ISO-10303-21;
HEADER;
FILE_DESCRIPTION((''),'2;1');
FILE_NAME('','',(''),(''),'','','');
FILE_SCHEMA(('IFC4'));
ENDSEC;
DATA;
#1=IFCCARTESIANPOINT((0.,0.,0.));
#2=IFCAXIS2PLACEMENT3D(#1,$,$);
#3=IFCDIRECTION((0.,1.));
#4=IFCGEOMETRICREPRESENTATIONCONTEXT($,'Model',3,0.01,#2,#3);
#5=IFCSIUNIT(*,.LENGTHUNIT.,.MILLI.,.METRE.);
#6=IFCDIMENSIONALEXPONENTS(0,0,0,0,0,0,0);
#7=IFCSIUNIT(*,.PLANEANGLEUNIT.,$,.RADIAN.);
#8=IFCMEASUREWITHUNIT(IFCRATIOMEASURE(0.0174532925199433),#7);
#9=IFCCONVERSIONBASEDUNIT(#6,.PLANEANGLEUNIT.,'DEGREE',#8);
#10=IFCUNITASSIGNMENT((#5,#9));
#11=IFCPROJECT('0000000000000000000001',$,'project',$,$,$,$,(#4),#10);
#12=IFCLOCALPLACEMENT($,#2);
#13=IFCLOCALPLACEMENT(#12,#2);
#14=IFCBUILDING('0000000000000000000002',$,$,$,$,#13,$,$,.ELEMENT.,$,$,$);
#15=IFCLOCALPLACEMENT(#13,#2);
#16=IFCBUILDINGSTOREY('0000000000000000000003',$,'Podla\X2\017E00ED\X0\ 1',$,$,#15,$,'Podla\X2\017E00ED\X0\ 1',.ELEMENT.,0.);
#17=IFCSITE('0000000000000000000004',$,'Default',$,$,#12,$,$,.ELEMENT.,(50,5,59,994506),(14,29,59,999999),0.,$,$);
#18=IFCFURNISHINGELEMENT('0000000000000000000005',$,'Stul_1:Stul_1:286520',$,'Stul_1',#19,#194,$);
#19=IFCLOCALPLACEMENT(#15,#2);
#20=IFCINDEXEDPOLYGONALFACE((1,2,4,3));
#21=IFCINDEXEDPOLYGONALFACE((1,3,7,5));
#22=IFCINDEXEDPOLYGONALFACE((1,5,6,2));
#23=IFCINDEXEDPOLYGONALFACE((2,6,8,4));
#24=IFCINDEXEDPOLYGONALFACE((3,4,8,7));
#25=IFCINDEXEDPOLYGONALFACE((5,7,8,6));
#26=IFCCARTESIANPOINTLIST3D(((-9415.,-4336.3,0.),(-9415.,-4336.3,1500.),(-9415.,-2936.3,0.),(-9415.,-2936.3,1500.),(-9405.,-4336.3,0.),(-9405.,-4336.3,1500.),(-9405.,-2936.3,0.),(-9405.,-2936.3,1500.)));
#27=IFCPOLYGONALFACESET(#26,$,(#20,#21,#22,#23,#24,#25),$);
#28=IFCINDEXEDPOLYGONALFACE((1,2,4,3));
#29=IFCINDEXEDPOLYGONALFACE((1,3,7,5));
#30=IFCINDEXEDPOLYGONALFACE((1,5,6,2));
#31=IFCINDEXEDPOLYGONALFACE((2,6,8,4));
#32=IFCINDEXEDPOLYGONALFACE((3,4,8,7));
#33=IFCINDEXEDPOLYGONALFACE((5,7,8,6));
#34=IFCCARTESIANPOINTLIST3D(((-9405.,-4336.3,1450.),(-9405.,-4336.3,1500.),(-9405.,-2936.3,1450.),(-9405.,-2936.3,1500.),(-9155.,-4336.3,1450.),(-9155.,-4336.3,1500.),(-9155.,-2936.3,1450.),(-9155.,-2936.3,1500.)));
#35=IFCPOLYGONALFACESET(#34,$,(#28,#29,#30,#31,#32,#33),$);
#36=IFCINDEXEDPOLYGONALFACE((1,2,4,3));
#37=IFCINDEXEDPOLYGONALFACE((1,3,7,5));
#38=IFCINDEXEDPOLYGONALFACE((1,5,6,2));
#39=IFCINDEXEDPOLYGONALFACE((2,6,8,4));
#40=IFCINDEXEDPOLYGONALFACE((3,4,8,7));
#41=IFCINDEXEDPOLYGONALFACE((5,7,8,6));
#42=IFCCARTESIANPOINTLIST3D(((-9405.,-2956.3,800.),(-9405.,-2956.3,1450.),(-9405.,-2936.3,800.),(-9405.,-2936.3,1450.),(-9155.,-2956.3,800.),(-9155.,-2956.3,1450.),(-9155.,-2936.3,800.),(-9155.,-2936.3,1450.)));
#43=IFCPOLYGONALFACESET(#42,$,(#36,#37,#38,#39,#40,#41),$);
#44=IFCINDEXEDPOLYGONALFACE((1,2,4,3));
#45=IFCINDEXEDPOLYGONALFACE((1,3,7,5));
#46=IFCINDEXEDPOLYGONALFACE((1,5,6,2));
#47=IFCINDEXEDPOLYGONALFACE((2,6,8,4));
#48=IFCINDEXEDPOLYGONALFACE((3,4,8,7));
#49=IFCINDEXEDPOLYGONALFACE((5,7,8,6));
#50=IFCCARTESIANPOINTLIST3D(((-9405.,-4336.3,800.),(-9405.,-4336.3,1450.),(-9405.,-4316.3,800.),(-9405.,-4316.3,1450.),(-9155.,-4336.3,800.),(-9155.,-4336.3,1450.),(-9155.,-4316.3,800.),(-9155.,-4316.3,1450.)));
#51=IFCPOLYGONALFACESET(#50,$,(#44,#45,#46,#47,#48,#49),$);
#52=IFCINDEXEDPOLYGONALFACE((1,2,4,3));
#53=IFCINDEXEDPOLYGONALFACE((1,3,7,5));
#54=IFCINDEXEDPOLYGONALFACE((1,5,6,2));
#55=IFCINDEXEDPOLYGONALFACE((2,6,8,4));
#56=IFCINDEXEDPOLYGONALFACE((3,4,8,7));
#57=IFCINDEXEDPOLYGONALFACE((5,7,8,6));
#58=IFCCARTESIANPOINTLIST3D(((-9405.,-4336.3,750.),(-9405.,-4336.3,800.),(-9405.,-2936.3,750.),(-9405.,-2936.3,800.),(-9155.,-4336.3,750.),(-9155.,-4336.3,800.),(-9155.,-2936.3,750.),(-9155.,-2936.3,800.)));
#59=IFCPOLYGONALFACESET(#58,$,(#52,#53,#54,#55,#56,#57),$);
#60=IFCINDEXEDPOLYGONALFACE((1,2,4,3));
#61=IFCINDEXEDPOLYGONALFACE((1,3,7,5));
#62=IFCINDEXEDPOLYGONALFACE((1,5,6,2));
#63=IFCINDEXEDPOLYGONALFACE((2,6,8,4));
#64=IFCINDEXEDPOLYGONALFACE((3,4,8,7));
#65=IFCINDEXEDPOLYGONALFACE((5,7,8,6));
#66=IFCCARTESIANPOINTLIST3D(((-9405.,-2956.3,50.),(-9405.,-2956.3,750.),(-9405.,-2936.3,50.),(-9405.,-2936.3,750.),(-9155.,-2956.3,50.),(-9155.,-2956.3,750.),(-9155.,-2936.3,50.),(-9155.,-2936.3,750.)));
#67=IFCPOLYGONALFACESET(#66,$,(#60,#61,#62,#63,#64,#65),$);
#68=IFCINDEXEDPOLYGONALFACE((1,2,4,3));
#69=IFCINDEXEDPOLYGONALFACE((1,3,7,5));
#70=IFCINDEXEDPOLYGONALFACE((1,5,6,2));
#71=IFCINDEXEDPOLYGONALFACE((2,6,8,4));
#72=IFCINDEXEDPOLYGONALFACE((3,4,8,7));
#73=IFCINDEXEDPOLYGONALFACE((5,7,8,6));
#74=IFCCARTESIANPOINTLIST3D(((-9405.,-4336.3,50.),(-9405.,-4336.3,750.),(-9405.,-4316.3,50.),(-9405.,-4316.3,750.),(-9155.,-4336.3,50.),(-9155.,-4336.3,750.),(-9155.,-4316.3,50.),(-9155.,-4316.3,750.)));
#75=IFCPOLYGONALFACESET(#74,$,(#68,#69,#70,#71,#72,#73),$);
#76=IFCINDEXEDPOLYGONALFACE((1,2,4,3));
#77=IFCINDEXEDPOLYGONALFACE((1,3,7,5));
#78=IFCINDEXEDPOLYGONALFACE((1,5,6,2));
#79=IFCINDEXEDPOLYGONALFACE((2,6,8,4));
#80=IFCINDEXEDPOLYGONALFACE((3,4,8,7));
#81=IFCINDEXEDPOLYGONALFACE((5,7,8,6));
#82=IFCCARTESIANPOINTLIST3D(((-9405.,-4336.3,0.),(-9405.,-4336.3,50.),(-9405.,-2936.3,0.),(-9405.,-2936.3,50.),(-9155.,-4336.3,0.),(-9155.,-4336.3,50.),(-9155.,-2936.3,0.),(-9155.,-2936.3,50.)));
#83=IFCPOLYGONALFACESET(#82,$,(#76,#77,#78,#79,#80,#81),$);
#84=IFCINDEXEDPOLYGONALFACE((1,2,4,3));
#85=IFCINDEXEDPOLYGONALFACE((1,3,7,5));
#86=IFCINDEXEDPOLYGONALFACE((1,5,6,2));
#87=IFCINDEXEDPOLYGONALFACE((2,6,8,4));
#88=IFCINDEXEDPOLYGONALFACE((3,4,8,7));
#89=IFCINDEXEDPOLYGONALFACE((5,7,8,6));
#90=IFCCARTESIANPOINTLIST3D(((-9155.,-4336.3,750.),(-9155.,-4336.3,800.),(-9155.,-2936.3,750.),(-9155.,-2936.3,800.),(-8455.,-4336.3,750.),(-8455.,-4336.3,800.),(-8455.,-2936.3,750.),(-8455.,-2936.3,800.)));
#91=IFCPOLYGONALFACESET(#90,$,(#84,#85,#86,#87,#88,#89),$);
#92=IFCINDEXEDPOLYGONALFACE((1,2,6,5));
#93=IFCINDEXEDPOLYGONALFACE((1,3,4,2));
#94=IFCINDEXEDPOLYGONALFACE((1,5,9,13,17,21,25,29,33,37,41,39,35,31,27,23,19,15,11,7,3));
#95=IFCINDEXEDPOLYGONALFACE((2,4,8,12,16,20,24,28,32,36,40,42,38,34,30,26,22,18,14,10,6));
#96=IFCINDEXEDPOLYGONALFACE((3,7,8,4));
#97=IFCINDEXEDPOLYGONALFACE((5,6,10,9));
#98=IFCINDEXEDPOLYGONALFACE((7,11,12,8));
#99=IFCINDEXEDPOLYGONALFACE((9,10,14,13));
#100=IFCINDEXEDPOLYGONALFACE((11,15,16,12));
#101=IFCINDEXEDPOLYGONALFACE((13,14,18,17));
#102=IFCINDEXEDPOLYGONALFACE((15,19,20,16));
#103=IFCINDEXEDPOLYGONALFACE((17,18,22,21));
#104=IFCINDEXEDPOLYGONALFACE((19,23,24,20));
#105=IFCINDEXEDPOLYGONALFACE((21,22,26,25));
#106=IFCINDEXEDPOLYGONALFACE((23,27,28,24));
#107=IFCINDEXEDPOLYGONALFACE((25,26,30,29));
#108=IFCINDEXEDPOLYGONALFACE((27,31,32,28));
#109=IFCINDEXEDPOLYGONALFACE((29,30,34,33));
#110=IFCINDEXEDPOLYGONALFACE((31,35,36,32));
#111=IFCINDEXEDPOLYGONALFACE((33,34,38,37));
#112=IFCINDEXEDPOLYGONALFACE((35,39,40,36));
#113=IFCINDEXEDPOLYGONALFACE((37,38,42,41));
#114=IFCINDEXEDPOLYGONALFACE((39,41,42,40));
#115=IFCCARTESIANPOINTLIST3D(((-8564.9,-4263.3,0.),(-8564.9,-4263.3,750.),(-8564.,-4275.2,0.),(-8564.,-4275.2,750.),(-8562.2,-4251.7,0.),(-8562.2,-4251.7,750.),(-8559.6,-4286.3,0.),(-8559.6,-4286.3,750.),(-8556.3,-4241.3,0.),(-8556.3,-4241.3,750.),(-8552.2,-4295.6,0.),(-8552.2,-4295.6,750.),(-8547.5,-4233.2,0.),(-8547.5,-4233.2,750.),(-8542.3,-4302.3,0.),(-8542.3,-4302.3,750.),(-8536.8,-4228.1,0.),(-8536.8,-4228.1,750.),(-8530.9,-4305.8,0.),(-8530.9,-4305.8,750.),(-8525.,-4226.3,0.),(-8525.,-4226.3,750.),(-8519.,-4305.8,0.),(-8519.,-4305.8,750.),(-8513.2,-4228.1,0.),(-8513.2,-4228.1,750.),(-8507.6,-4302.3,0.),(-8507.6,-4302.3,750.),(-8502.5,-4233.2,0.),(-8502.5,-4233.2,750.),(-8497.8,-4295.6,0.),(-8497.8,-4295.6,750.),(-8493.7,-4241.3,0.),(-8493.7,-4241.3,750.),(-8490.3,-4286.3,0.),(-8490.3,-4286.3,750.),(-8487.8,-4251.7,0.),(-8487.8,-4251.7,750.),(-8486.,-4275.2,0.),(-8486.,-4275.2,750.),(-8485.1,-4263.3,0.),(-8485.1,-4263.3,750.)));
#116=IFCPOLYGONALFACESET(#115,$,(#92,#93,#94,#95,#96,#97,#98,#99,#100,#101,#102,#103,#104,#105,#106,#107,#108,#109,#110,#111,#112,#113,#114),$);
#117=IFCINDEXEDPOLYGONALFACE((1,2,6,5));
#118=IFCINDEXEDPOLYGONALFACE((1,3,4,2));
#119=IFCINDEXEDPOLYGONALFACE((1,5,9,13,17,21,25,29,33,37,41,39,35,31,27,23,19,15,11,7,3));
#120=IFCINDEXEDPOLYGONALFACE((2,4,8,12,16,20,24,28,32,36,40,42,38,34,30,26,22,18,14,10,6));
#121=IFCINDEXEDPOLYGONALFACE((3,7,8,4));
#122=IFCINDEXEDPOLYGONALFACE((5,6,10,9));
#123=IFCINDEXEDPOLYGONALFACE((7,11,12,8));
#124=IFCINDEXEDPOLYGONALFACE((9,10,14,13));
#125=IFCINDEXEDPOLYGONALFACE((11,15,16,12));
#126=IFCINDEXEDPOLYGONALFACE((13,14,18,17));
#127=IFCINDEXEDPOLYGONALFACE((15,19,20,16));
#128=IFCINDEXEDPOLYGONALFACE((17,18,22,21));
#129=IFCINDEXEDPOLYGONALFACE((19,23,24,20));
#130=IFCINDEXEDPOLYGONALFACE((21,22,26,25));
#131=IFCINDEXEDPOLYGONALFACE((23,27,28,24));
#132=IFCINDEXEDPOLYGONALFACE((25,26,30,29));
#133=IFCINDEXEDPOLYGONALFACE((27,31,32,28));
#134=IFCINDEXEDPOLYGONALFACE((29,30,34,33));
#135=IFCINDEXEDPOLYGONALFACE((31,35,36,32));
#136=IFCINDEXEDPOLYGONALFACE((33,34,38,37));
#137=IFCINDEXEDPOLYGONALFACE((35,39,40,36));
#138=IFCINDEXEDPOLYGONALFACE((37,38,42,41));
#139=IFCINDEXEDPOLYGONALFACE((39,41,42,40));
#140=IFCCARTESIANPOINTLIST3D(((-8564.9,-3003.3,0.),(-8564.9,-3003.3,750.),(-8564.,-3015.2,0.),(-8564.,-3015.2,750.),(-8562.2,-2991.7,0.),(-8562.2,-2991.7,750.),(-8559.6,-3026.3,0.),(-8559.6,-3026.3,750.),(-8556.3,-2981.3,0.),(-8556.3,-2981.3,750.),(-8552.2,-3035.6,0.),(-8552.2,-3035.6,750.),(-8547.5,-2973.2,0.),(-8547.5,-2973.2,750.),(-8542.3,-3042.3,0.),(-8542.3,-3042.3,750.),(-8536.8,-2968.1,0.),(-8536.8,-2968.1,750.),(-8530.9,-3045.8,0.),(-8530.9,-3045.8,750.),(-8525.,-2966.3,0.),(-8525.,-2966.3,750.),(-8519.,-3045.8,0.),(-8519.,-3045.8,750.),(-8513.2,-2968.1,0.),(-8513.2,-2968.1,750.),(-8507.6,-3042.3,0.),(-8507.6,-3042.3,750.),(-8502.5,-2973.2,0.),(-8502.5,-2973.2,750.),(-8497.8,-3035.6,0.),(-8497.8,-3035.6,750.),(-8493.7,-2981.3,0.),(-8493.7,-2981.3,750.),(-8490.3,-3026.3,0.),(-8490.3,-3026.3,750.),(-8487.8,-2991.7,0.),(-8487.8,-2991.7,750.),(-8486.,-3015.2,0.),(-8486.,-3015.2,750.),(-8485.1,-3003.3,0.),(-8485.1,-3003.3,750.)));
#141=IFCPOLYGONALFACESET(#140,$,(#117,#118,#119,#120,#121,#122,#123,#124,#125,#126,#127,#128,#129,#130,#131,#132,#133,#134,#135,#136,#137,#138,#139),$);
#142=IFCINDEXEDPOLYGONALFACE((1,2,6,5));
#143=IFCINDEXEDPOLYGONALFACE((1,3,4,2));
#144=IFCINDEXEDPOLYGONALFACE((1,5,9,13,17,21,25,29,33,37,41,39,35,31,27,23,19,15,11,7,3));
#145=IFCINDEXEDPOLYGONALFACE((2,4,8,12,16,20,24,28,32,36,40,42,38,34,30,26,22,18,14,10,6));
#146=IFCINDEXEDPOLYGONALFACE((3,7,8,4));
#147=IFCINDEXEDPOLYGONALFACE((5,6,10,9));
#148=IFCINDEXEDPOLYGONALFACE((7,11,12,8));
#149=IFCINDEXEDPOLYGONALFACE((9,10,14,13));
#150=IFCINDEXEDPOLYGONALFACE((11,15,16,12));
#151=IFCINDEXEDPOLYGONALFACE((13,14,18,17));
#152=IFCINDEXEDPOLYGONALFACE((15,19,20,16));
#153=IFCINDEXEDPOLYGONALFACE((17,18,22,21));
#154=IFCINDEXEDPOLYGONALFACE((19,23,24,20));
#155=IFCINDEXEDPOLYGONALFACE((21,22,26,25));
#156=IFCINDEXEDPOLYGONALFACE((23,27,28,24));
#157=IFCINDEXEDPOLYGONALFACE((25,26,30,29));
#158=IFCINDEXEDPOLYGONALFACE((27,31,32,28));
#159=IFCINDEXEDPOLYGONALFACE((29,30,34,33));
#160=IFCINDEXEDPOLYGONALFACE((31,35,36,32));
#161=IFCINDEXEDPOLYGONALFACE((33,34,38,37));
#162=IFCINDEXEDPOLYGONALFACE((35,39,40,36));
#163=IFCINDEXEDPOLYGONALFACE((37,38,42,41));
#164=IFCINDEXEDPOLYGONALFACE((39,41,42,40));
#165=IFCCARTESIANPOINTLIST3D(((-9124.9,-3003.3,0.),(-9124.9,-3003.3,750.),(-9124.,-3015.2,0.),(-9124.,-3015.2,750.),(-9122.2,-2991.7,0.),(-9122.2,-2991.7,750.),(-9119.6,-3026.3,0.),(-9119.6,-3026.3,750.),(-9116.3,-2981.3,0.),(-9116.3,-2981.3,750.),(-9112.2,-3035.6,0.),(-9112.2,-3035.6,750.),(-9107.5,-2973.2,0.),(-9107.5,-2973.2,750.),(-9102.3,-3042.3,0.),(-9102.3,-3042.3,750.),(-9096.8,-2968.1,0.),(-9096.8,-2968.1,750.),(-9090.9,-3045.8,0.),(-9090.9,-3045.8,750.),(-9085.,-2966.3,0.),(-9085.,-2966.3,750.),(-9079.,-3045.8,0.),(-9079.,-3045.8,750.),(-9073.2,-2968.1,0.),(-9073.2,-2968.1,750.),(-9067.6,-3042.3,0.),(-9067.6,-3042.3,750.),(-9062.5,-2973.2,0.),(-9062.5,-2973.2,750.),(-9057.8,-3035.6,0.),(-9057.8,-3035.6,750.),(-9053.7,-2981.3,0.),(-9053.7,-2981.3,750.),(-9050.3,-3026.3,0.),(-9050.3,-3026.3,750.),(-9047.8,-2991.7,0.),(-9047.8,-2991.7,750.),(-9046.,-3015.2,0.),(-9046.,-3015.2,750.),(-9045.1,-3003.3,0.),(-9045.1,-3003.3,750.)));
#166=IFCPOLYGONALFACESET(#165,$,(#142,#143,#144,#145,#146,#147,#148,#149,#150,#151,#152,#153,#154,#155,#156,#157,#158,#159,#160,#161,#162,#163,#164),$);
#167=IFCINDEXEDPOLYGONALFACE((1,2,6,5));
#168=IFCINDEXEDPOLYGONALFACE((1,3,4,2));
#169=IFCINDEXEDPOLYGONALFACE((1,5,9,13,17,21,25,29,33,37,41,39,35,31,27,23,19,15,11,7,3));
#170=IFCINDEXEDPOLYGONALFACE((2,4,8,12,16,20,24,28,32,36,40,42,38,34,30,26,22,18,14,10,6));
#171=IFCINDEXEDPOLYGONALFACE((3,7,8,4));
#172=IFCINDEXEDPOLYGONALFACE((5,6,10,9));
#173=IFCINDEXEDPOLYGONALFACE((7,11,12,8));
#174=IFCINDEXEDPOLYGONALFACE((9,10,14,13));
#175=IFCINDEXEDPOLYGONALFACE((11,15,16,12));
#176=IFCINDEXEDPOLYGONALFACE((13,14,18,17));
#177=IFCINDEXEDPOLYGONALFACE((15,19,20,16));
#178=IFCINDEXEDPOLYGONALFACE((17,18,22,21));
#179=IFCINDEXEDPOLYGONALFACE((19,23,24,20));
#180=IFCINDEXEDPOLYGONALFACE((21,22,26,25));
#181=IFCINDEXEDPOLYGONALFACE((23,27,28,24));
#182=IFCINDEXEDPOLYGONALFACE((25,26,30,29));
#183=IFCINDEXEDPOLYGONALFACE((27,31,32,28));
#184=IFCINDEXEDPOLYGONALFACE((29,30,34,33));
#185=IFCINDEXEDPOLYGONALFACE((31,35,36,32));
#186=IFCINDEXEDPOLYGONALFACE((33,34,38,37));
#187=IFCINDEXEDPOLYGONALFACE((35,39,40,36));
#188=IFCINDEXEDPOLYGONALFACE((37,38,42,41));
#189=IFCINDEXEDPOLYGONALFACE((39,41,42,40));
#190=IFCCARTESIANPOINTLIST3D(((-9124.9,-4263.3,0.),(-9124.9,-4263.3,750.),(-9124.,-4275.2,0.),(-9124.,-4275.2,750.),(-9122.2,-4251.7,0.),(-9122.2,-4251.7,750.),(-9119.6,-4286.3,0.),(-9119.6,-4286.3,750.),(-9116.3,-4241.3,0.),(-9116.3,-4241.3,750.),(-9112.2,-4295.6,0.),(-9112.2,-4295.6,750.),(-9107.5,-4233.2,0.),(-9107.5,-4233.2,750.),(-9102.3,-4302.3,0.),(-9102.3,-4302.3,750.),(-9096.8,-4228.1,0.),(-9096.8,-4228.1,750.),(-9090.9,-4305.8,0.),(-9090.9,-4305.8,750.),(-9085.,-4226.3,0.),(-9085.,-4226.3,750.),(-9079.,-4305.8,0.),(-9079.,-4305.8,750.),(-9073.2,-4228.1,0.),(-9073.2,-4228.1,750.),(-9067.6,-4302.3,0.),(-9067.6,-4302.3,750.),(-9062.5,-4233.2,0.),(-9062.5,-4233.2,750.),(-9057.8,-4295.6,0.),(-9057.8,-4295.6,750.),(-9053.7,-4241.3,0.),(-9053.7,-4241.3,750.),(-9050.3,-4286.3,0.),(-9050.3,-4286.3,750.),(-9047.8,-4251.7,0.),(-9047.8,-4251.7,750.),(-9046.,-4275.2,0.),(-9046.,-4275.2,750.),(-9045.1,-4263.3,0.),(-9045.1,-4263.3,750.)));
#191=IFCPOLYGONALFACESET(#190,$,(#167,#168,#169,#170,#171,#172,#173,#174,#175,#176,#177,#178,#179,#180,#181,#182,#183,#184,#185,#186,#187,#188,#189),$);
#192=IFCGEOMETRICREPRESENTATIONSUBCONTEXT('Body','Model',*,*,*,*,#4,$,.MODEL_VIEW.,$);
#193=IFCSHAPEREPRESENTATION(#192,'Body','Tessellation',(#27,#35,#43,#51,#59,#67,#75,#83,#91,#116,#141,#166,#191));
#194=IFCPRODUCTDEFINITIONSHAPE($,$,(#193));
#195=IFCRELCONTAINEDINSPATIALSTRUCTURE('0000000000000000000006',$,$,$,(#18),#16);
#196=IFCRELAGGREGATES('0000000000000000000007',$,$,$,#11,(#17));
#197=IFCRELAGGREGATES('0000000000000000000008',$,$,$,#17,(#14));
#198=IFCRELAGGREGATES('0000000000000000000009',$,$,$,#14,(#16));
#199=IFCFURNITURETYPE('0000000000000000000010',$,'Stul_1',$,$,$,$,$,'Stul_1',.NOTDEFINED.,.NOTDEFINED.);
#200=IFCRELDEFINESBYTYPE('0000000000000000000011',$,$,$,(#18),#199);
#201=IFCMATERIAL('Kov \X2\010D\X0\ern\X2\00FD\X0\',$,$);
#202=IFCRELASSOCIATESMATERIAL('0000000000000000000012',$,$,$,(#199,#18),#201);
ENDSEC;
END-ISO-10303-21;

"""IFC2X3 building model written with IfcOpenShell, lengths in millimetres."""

from ifc_helpers import new_model, entity, si_unit, converted_unit, direction, frame, frame_2d, origin, origin_2d_with_axis, place, context, subcontext, project, spatial, rectangle, circle, extrude, source, transform, mapped, material, type_object, type_shapes, element, save


model = new_model("IFC2X3")

# Units and contexts
model_context = context("Model", 3, precision=0.01, world=origin(), true_north=direction((0.0, 1.0)))
body_context = subcontext(model_context, "Body", "Model", "MODEL_VIEW")
ifc_project = project(units=[si_unit("LENGTHUNIT", "METRE", prefix="MILLI"), converted_unit("PLANEANGLEUNIT", "DEGREE", entity("IfcRatioMeasure", 0.0174532925199433), si_unit("PLANEANGLEUNIT", "RADIAN"), dimensions=[0, 0, 0, 0, 0, 0, 0])], contexts=[model_context])

# Site, building, storey
site_placement = place(None, origin())
site = spatial("IfcSite", under=ifc_project, at=site_placement, Name="Default", CompositionType="ELEMENT", RefLatitude=(50, 5, 59, 994506), RefLongitude=(14, 29, 59, 999999), RefElevation=0.0)
building_placement = place(site_placement, origin())
building = spatial("IfcBuilding", under=site, at=building_placement, CompositionType="ELEMENT")
storey_placement = place(building_placement, origin())
storey = spatial("IfcBuildingStorey", under=building, at=storey_placement, Name="Podlaží 1", LongName="Podlaží 1", CompositionType="ELEMENT", Elevation=0.0)

# Furnishing element
ifc_material_1 = material(Name="Kov černý")
furniture_type = type_object("IfcFurnitureType", Name="Stul_1", ElementType="Stul_1", material=ifc_material_1)
shared_shape_1 = source(origin(), body_context, "Body", "SweptSolid", [
    extrude(rectangle(XDim=1400.0, YDim=10.0, at=origin_2d_with_axis()), frame((0.0, 605.0, 0.0), z_axis=(0.0, 0.0, 1.0), x_axis=(-1.0, 0.0, 0.0)), (0.0, 0.0, 1.0), 1500.0),
    extrude(rectangle(XDim=1400.0, YDim=250.0, at=frame_2d((0.0, 0.0), x_axis=(1.0, 0.0))), frame((0.0, 475.0, 1450.0), z_axis=(0.0, 0.0, 1.0), x_axis=(-1.0, 0.0, 0.0)), (0.0, 0.0, 1.0), 50.0),
    extrude(rectangle(XDim=20.0, YDim=250.0, at=origin_2d_with_axis()), frame((690.0, 475.0, 800.0), z_axis=(0.0, 0.0, 1.0), x_axis=(-1.0, 0.0, 0.0)), (0.0, 0.0, 1.0), 650.0),
    extrude(rectangle(XDim=20.0, YDim=250.0, at=frame_2d((0.0, 0.0), x_axis=(1.0, 0.0))), frame((-690.0, 475.0, 800.0), z_axis=(0.0, 0.0, 1.0), x_axis=(-1.0, 0.0, 0.0)), (0.0, 0.0, 1.0), 650.0),
    extrude(rectangle(XDim=1400.0, YDim=250.0, at=origin_2d_with_axis()), frame((0.0, 475.0, 750.0), z_axis=(0.0, 0.0, 1.0), x_axis=(-1.0, 0.0, 0.0)), (0.0, 0.0, 1.0), 50.0),
    extrude(rectangle(XDim=20.0, YDim=250.0, at=origin_2d_with_axis()), frame((690.0, 475.0, 50.0), z_axis=(0.0, 0.0, 1.0), x_axis=(-1.0, 0.0, 0.0)), (0.0, 0.0, 1.0), 700.0),
    extrude(rectangle(XDim=20.0, YDim=250.0, at=frame_2d((0.0, 0.0), x_axis=(1.0, 0.0))), frame((-690.0, 475.0, 50.0), z_axis=(0.0, 0.0, 1.0), x_axis=(-1.0, 0.0, 0.0)), (0.0, 0.0, 1.0), 700.0),
    extrude(rectangle(XDim=1400.0, YDim=250.0, at=origin_2d_with_axis()), frame((0.0, 475.0, 0.0), z_axis=(0.0, 0.0, 1.0), x_axis=(-1.0, 0.0, 0.0)), (0.0, 0.0, 1.0), 50.0),
    extrude(rectangle(XDim=1400.0, YDim=700.0, at=origin_2d_with_axis()), frame((0.0, 0.0, 750.0), z_axis=(0.0, 0.0, 1.0), x_axis=(-1.0, 0.0, 0.0)), (0.0, 0.0, 1.0), 50.0),
    extrude(circle(Radius=40.0, at=frame_2d((0.0, 0.0), x_axis=(1.0, 0.0))), frame((-630.0, -280.0, 0.0)), (0.0, 0.0, 1.0), 750.0),
    extrude(circle(Radius=40.0, at=frame_2d((0.0, 0.0), x_axis=(1.0, 0.0))), frame((630.0, -280.0, 0.0)), (0.0, 0.0, 1.0), 750.0),
    extrude(circle(Radius=40.0, at=frame_2d((0.0, 0.0), x_axis=(1.0, 0.0))), frame((630.0, 280.0, 0.0)), (0.0, 0.0, 1.0), 750.0),
    extrude(circle(Radius=40.0, at=frame_2d((0.0, 0.0), x_axis=(1.0, 0.0))), frame((-630.0, 280.0, 0.0)), (0.0, 0.0, 1.0), 750.0),
])
type_shapes(furniture_type, [shared_shape_1])
for number, where, z_axis, x_axis, name in (
    (1, (-8805.0, -3636.3, 0.0), (0.0, 0.0, 1.0), (0.0, 1.0, 0.0), "Stul_1:Stul_1:286520"),
):
    element("IfcFurnishingElement", number, at=place(storey_placement, frame(where, z_axis=z_axis, x_axis=x_axis)), inside=storey, type_object=furniture_type, material=ifc_material_1, Name=name, ObjectType="Stul_1", context=body_context, shape_type="MappedRepresentation", body=[
        mapped(shared_shape_1, transform((0.0, 0.0, 0.0), scale=1.0)),
    ])

save(model, "model.ifc")
